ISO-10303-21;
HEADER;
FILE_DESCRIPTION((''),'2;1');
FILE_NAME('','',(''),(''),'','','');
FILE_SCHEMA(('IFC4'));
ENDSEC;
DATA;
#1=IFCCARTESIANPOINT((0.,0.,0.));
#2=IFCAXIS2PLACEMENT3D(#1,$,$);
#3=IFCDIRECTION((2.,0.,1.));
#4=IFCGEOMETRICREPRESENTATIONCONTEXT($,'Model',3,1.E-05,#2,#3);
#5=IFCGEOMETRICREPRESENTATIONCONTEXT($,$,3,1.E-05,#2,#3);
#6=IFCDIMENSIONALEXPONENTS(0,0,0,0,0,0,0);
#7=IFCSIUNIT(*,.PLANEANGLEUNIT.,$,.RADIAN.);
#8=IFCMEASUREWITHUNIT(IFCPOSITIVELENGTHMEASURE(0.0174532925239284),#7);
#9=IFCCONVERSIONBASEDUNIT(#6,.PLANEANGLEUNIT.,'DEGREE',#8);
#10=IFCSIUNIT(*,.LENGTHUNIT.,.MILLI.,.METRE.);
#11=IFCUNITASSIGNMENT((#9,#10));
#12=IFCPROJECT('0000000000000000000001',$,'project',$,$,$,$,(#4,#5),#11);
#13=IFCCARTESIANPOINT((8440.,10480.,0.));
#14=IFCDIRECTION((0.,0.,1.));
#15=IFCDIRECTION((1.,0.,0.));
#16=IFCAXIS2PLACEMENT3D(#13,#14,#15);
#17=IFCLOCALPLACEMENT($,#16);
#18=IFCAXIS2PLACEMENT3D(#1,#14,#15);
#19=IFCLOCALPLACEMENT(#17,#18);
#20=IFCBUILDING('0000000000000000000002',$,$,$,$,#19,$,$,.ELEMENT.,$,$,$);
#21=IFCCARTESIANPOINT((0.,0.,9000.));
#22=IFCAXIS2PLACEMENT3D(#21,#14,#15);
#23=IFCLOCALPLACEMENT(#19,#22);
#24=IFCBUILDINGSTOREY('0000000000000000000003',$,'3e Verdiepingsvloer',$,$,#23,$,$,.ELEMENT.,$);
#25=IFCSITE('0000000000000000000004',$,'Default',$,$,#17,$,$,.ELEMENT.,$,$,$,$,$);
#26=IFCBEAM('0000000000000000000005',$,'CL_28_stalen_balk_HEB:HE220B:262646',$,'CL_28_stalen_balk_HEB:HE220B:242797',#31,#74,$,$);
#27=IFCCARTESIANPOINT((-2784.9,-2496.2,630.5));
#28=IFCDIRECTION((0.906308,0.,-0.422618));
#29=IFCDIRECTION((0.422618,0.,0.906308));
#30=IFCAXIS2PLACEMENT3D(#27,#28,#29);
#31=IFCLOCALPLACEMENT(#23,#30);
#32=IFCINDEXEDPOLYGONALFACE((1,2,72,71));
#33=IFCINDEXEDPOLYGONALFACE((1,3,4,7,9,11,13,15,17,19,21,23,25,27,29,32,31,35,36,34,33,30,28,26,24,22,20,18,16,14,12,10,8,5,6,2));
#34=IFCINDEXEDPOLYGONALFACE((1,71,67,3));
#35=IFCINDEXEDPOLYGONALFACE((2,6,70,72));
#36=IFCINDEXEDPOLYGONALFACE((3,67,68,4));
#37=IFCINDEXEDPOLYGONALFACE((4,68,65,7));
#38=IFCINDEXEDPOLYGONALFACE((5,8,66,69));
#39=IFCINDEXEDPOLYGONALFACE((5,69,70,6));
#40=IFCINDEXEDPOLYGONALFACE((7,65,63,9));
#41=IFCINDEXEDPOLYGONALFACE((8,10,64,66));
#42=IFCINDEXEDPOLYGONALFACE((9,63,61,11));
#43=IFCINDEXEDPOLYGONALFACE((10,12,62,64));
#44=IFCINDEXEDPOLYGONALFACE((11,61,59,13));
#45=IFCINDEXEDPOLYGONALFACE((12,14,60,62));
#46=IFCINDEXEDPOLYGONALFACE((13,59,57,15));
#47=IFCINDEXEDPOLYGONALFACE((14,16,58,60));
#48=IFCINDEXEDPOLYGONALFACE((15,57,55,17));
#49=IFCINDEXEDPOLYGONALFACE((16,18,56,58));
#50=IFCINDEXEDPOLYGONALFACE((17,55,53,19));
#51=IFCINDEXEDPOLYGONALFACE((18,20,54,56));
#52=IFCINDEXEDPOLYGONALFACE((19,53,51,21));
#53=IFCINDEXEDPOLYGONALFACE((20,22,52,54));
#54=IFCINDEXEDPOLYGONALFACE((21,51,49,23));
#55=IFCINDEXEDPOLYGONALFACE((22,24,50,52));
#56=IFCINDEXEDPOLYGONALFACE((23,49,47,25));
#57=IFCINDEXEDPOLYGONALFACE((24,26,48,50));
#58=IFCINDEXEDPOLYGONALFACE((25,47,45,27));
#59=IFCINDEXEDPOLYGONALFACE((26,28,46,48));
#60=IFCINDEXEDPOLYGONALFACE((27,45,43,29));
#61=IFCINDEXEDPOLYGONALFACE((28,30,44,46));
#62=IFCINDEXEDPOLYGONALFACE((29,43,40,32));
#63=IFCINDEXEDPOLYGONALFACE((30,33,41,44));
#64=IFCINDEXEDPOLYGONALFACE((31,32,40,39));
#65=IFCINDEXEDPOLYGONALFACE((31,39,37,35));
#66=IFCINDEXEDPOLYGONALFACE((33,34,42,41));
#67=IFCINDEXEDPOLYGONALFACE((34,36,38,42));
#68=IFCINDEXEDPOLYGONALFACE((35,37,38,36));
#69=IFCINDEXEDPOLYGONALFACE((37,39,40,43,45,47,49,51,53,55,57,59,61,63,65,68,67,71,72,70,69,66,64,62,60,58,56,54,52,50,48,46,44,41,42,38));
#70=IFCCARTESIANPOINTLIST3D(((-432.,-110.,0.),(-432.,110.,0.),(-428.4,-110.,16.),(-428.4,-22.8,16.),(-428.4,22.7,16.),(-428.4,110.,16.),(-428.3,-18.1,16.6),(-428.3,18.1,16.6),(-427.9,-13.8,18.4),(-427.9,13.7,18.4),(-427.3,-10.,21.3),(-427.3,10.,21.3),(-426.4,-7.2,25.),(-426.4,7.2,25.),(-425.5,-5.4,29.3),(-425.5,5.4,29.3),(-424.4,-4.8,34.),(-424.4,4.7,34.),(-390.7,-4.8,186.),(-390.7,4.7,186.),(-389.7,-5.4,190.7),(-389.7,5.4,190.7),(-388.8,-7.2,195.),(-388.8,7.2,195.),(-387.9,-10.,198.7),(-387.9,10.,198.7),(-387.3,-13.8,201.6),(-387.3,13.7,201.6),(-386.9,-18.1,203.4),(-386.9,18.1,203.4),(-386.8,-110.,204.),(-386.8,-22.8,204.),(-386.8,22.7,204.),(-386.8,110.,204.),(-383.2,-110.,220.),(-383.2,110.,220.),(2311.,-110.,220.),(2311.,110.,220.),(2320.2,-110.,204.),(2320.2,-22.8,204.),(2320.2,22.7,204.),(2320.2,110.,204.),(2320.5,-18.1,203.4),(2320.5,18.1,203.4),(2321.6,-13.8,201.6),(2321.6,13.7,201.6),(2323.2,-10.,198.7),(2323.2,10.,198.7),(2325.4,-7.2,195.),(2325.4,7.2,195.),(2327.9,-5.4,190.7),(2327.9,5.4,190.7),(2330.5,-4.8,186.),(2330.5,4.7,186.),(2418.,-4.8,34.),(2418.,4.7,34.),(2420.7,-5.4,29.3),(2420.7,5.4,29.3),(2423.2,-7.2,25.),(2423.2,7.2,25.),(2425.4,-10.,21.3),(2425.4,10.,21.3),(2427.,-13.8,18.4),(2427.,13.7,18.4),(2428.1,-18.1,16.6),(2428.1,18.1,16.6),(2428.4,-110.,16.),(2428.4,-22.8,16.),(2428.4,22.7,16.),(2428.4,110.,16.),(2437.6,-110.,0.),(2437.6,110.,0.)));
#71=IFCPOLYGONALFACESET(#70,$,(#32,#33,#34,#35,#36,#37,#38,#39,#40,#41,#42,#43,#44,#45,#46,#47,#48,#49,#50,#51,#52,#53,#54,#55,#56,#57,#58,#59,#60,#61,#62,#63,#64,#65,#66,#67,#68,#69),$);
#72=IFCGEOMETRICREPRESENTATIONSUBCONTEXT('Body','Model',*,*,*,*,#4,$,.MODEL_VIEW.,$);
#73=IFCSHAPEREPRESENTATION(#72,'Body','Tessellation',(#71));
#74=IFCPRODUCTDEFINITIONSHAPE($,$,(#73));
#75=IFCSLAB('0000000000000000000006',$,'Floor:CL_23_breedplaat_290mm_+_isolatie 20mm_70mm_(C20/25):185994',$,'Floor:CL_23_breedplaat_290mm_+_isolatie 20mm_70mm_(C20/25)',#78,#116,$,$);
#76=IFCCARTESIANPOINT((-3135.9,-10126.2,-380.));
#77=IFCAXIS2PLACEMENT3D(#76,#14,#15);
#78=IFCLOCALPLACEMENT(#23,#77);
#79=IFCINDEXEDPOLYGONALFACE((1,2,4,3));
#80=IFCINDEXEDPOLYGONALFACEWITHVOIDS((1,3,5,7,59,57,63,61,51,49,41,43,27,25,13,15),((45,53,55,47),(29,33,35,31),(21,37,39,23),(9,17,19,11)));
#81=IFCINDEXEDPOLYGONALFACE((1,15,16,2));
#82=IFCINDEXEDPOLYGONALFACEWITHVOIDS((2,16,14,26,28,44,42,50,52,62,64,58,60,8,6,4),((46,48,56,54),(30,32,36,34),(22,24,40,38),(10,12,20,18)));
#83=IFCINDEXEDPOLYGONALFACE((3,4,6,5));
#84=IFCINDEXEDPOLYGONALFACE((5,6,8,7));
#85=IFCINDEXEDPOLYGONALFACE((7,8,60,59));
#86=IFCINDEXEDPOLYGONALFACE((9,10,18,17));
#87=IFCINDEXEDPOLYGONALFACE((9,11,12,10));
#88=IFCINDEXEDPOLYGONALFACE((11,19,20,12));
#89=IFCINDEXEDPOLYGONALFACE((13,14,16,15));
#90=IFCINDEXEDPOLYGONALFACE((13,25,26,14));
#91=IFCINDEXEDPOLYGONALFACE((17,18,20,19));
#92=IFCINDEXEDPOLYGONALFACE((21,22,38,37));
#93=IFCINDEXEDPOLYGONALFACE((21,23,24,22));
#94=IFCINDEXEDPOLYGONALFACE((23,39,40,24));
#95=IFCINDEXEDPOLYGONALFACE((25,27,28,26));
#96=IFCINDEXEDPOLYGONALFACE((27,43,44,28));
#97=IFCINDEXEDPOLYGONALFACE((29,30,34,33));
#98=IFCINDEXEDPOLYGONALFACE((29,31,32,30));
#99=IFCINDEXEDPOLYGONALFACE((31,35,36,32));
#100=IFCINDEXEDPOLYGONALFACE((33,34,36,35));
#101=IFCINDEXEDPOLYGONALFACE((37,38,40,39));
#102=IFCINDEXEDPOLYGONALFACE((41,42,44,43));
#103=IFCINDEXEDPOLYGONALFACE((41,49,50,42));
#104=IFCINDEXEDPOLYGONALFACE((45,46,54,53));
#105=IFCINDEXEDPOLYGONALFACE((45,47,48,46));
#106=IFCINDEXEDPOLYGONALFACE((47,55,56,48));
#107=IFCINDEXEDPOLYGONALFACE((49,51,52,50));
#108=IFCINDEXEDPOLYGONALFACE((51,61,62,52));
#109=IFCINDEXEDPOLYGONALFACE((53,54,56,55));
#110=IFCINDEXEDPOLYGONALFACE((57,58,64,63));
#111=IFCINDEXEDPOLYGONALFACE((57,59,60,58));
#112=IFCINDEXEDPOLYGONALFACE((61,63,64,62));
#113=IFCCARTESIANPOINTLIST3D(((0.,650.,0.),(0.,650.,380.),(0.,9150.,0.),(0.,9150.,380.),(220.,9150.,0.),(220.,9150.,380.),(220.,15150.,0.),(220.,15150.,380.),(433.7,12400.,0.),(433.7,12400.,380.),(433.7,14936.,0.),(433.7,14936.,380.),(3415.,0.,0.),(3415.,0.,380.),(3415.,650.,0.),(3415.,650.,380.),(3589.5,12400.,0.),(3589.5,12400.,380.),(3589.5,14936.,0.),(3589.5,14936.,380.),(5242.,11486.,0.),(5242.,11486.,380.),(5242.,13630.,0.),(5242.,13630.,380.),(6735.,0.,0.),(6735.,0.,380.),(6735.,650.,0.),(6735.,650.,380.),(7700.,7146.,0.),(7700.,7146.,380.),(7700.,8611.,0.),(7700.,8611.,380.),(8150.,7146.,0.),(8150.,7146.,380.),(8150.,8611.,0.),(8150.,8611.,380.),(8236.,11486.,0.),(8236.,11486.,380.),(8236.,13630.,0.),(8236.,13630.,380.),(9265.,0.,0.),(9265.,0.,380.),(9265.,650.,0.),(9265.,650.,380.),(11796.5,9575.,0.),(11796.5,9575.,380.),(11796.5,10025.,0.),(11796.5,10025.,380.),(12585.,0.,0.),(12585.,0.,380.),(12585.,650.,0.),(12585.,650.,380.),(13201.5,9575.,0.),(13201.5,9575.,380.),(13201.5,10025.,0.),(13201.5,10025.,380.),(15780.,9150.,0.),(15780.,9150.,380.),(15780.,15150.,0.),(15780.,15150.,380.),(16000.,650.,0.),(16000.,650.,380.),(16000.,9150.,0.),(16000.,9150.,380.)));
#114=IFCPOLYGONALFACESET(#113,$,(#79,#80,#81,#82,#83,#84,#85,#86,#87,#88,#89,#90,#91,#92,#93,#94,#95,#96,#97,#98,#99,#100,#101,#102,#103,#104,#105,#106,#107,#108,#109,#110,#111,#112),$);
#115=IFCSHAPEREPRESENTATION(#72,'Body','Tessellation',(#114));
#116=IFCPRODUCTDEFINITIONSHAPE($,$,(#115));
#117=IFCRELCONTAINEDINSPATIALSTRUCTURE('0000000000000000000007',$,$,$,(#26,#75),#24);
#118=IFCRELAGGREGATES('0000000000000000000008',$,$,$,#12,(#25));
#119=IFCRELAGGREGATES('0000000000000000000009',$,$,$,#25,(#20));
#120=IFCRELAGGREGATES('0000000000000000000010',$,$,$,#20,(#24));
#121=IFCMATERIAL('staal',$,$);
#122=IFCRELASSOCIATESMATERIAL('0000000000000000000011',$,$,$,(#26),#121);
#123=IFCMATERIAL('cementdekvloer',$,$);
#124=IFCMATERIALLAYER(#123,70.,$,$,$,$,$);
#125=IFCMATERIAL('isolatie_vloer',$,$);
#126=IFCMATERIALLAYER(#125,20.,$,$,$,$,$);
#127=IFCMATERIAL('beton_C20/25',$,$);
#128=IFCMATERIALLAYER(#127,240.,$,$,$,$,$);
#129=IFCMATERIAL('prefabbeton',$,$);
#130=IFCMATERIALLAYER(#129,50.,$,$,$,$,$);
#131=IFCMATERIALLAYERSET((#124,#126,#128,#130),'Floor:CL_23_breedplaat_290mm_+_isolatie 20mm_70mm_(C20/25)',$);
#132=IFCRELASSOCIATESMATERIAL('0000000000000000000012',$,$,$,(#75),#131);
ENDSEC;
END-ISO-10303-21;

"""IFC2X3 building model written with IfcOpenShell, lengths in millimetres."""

from ifc_helpers import new_model, entity, si_unit, converted_unit, direction, frame, frame_2d, origin, origin_with_axes, origin_2d_with_axis, place, context, subcontext, project, spatial, polyline, rectangle, i_section, outline, extrude, clip, halfspace, source, transform, mapped, material, layer, layer_set, layer_usage, element, save


model = new_model("IFC2X3")

# Units and contexts
model_context = context("Model", 3, precision=1e-05, world=origin(), true_north=direction((2.0, 0.0, 1.0)))
context_of_model = context(None, 3, precision=1e-05, world=origin(), true_north=direction((2.0, 0.0, 1.0)))
body_context = subcontext(model_context, "Body", "Model", "MODEL_VIEW")
ifc_project = project(units=[converted_unit("PLANEANGLEUNIT", "DEGREE", entity("IfcPositiveLengthMeasure", 0.0174532925239284), si_unit("PLANEANGLEUNIT", "RADIAN"), dimensions=[0, 0, 0, 0, 0, 0, 0]), si_unit("LENGTHUNIT", "METRE", prefix="MILLI")], contexts=[model_context, context_of_model])

# Site, building, storey
site_placement = place(None, frame((8440.0, 10480.0, 0.0), z_axis=(0.0, 0.0, 1.0), x_axis=(1.0, 0.0, 0.0)))
site = spatial("IfcSite", under=ifc_project, at=site_placement, Name="Default", CompositionType="ELEMENT")
building_placement = place(site_placement, origin_with_axes())
building = spatial("IfcBuilding", under=site, at=building_placement, CompositionType="ELEMENT")
storey_placement = place(building_placement, frame((0.0, 0.0, 9000.0), z_axis=(0.0, 0.0, 1.0), x_axis=(1.0, 0.0, 0.0)))
storey = spatial("IfcBuildingStorey", under=building, at=storey_placement, Name="3e Verdiepingsvloer", CompositionType="ELEMENT")

# Beam
ifc_material_1 = material(Name="staal")
beam_1_placement = place(storey_placement, frame((-2784.9, -2496.2, 630.5), z_axis=(0.906308, 0.0, -0.422618), x_axis=(0.422618, 0.0, 0.906308)))
element("IfcBeam", 1, at=beam_1_placement, inside=storey, material=ifc_material_1, Name="CL_28_stalen_balk_HEB:HE220B:262646", ObjectType="CL_28_stalen_balk_HEB:HE220B:242797", context=body_context, shape_type="Clipping", body=[
    clip(clip(extrude(i_section(OverallWidth=220.0, OverallDepth=220.0, WebThickness=9.5, FlangeThickness=16.0, FilletRadius=18.0, at=frame_2d((0.0, 0.0), x_axis=(0.0, 1.0))), frame((-432.0, 0.0, 110.0), z_axis=(1.0, 0.0, 0.0), x_axis=(0.0, 0.0, -1.0)), (0.0, 0.0, 1.0), 2869.6), halfspace(frame((-500.2, -667.6, -307.6), z_axis=(-0.976296, 0.0, 0.21644), x_axis=(0.21644, 0.0, 0.976296)), False)), halfspace(frame((2444.9, 5856.2, -12.6), z_axis=(0.86662, 0.0, 0.498969), x_axis=(-0.498969, 0.0, 0.86662)), False)),
])

# Slab, openings
ifc_material_2 = material(Name="cementdekvloer")
ifc_layer_1 = layer(ifc_material_2, 70.0)
ifc_material_3 = material(Name="isolatie_vloer")
ifc_layer_2 = layer(ifc_material_3, 20.0)
ifc_material_4 = material(Name="beton_C20/25")
ifc_layer_3 = layer(ifc_material_4, 240.0)
ifc_material_5 = material(Name="prefabbeton")
ifc_layer_4 = layer(ifc_material_5, 50.0)
ifc_layer_set_1 = layer_set([ifc_layer_1, ifc_layer_2, ifc_layer_3, ifc_layer_4], Name="Floor:CL_23_breedplaat_290mm_+_isolatie 20mm_70mm_(C20/25)")
ifc_layer_usage_1 = layer_usage(ifc_layer_set_1, "AXIS3", "POSITIVE", 0.0)
slab_placement = place(storey_placement, frame((-3135.9, -10126.2, -380.0), z_axis=(0.0, 0.0, 1.0), x_axis=(1.0, 0.0, 0.0)))
slab = element("IfcSlab", 2, at=slab_placement, inside=storey, material=ifc_layer_usage_1, Name="Floor:CL_23_breedplaat_290mm_+_isolatie 20mm_70mm_(C20/25):185994", ObjectType="Floor:CL_23_breedplaat_290mm_+_isolatie 20mm_70mm_(C20/25)", context=body_context, shape_type="SweptSolid", body=[
    extrude(outline(polyline([(7780.0, 7575.0), (-7780.0, 7575.0), (-7780.0, 1575.0), (-8000.0, 1575.0), (-8000.0, -6925.0), (-4585.0, -6925.0), (-4585.0, -7575.0), (-1265.0, -7575.0), (-1265.0, -6925.0), (1265.0, -6925.0), (1265.0, -7575.0), (4585.0, -7575.0), (4585.0, -6925.0), (8000.0, -6925.0), (8000.0, 1575.0), (7780.0, 1575.0), (7780.0, 7575.0)])), frame((8000.0, 7575.0, 380.0), z_axis=(0.0, 0.0, -1.0), x_axis=(-1.0, 0.0, 0.0)), (0.0, 0.0, 1.0), 380.0),
])
shared_shape_1 = source(origin(), body_context, "Body", "SweptSolid", [
    extrude(rectangle(XDim=3155.8, YDim=2536.0, at=origin_2d_with_axis()), frame((0.0, 0.0, 0.0), z_axis=(0.0, 0.0, -1.0), x_axis=(-1.0, 0.0, 0.0)), (0.0, 0.0, 1.0), 380.0),
])
opening_1_placement = place(slab_placement, frame((2011.6, 13668.0, 380.0), z_axis=(0.0, 0.0, 1.0), x_axis=(1.0, 0.0, 0.0)))
element("IfcOpeningElement", 3, at=opening_1_placement, cuts=slab, ObjectType="Opening", context=body_context, shape_type="MappedRepresentation", body=[
    mapped(shared_shape_1, transform((0.0, 0.0, 0.0))),
])
shared_shape_2 = source(origin(), body_context, "Body", "SweptSolid", [
    extrude(rectangle(XDim=2144.0, YDim=2994.0, at=origin_2d_with_axis()), frame((0.0, 0.0, 0.0), z_axis=(0.0, 0.0, -1.0), x_axis=(0.0, -1.0, 0.0)), (0.0, 0.0, 1.0), 380.0),
])
opening_2_placement = place(slab_placement, frame((6739.0, 12558.0, 380.0), z_axis=(0.0, 0.0, 1.0), x_axis=(1.0, 0.0, 0.0)))
element("IfcOpeningElement", 4, at=opening_2_placement, cuts=slab, ObjectType="Opening", context=body_context, shape_type="MappedRepresentation", body=[
    mapped(shared_shape_2, transform((0.0, 0.0, 0.0))),
])
shared_shape_3 = source(origin(), body_context, "Body", "SweptSolid", [
    extrude(rectangle(XDim=450.0, YDim=1405.0, at=origin_2d_with_axis()), frame((0.0, 0.0, 0.0), z_axis=(0.0, 0.0, -1.0), x_axis=(0.0, -1.0, 0.0)), (0.0, 0.0, 1.0), 380.0),
])
opening_3_placement = place(slab_placement, frame((12499.0, 9800.0, 380.0), z_axis=(0.0, 0.0, 1.0), x_axis=(1.0, 0.0, 0.0)))
element("IfcOpeningElement", 5, at=opening_3_placement, cuts=slab, ObjectType="Opening", context=body_context, shape_type="MappedRepresentation", body=[
    mapped(shared_shape_3, transform((0.0, 0.0, 0.0))),
])
shared_shape_4 = source(origin(), body_context, "Body", "SweptSolid", [
    extrude(rectangle(XDim=1465.0, YDim=450.0, at=origin_2d_with_axis()), frame((0.0, 0.0, 0.0), z_axis=(0.0, 0.0, -1.0), x_axis=(0.0, -1.0, 0.0)), (0.0, 0.0, 1.0), 380.0),
])
opening_4_placement = place(slab_placement, frame((7925.0, 7878.5, 380.0), z_axis=(0.0, 0.0, 1.0), x_axis=(1.0, 0.0, 0.0)))
element("IfcOpeningElement", 6, at=opening_4_placement, cuts=slab, ObjectType="Opening", context=body_context, shape_type="MappedRepresentation", body=[
    mapped(shared_shape_4, transform((0.0, 0.0, 0.0))),
])

save(model, "model.ifc")
